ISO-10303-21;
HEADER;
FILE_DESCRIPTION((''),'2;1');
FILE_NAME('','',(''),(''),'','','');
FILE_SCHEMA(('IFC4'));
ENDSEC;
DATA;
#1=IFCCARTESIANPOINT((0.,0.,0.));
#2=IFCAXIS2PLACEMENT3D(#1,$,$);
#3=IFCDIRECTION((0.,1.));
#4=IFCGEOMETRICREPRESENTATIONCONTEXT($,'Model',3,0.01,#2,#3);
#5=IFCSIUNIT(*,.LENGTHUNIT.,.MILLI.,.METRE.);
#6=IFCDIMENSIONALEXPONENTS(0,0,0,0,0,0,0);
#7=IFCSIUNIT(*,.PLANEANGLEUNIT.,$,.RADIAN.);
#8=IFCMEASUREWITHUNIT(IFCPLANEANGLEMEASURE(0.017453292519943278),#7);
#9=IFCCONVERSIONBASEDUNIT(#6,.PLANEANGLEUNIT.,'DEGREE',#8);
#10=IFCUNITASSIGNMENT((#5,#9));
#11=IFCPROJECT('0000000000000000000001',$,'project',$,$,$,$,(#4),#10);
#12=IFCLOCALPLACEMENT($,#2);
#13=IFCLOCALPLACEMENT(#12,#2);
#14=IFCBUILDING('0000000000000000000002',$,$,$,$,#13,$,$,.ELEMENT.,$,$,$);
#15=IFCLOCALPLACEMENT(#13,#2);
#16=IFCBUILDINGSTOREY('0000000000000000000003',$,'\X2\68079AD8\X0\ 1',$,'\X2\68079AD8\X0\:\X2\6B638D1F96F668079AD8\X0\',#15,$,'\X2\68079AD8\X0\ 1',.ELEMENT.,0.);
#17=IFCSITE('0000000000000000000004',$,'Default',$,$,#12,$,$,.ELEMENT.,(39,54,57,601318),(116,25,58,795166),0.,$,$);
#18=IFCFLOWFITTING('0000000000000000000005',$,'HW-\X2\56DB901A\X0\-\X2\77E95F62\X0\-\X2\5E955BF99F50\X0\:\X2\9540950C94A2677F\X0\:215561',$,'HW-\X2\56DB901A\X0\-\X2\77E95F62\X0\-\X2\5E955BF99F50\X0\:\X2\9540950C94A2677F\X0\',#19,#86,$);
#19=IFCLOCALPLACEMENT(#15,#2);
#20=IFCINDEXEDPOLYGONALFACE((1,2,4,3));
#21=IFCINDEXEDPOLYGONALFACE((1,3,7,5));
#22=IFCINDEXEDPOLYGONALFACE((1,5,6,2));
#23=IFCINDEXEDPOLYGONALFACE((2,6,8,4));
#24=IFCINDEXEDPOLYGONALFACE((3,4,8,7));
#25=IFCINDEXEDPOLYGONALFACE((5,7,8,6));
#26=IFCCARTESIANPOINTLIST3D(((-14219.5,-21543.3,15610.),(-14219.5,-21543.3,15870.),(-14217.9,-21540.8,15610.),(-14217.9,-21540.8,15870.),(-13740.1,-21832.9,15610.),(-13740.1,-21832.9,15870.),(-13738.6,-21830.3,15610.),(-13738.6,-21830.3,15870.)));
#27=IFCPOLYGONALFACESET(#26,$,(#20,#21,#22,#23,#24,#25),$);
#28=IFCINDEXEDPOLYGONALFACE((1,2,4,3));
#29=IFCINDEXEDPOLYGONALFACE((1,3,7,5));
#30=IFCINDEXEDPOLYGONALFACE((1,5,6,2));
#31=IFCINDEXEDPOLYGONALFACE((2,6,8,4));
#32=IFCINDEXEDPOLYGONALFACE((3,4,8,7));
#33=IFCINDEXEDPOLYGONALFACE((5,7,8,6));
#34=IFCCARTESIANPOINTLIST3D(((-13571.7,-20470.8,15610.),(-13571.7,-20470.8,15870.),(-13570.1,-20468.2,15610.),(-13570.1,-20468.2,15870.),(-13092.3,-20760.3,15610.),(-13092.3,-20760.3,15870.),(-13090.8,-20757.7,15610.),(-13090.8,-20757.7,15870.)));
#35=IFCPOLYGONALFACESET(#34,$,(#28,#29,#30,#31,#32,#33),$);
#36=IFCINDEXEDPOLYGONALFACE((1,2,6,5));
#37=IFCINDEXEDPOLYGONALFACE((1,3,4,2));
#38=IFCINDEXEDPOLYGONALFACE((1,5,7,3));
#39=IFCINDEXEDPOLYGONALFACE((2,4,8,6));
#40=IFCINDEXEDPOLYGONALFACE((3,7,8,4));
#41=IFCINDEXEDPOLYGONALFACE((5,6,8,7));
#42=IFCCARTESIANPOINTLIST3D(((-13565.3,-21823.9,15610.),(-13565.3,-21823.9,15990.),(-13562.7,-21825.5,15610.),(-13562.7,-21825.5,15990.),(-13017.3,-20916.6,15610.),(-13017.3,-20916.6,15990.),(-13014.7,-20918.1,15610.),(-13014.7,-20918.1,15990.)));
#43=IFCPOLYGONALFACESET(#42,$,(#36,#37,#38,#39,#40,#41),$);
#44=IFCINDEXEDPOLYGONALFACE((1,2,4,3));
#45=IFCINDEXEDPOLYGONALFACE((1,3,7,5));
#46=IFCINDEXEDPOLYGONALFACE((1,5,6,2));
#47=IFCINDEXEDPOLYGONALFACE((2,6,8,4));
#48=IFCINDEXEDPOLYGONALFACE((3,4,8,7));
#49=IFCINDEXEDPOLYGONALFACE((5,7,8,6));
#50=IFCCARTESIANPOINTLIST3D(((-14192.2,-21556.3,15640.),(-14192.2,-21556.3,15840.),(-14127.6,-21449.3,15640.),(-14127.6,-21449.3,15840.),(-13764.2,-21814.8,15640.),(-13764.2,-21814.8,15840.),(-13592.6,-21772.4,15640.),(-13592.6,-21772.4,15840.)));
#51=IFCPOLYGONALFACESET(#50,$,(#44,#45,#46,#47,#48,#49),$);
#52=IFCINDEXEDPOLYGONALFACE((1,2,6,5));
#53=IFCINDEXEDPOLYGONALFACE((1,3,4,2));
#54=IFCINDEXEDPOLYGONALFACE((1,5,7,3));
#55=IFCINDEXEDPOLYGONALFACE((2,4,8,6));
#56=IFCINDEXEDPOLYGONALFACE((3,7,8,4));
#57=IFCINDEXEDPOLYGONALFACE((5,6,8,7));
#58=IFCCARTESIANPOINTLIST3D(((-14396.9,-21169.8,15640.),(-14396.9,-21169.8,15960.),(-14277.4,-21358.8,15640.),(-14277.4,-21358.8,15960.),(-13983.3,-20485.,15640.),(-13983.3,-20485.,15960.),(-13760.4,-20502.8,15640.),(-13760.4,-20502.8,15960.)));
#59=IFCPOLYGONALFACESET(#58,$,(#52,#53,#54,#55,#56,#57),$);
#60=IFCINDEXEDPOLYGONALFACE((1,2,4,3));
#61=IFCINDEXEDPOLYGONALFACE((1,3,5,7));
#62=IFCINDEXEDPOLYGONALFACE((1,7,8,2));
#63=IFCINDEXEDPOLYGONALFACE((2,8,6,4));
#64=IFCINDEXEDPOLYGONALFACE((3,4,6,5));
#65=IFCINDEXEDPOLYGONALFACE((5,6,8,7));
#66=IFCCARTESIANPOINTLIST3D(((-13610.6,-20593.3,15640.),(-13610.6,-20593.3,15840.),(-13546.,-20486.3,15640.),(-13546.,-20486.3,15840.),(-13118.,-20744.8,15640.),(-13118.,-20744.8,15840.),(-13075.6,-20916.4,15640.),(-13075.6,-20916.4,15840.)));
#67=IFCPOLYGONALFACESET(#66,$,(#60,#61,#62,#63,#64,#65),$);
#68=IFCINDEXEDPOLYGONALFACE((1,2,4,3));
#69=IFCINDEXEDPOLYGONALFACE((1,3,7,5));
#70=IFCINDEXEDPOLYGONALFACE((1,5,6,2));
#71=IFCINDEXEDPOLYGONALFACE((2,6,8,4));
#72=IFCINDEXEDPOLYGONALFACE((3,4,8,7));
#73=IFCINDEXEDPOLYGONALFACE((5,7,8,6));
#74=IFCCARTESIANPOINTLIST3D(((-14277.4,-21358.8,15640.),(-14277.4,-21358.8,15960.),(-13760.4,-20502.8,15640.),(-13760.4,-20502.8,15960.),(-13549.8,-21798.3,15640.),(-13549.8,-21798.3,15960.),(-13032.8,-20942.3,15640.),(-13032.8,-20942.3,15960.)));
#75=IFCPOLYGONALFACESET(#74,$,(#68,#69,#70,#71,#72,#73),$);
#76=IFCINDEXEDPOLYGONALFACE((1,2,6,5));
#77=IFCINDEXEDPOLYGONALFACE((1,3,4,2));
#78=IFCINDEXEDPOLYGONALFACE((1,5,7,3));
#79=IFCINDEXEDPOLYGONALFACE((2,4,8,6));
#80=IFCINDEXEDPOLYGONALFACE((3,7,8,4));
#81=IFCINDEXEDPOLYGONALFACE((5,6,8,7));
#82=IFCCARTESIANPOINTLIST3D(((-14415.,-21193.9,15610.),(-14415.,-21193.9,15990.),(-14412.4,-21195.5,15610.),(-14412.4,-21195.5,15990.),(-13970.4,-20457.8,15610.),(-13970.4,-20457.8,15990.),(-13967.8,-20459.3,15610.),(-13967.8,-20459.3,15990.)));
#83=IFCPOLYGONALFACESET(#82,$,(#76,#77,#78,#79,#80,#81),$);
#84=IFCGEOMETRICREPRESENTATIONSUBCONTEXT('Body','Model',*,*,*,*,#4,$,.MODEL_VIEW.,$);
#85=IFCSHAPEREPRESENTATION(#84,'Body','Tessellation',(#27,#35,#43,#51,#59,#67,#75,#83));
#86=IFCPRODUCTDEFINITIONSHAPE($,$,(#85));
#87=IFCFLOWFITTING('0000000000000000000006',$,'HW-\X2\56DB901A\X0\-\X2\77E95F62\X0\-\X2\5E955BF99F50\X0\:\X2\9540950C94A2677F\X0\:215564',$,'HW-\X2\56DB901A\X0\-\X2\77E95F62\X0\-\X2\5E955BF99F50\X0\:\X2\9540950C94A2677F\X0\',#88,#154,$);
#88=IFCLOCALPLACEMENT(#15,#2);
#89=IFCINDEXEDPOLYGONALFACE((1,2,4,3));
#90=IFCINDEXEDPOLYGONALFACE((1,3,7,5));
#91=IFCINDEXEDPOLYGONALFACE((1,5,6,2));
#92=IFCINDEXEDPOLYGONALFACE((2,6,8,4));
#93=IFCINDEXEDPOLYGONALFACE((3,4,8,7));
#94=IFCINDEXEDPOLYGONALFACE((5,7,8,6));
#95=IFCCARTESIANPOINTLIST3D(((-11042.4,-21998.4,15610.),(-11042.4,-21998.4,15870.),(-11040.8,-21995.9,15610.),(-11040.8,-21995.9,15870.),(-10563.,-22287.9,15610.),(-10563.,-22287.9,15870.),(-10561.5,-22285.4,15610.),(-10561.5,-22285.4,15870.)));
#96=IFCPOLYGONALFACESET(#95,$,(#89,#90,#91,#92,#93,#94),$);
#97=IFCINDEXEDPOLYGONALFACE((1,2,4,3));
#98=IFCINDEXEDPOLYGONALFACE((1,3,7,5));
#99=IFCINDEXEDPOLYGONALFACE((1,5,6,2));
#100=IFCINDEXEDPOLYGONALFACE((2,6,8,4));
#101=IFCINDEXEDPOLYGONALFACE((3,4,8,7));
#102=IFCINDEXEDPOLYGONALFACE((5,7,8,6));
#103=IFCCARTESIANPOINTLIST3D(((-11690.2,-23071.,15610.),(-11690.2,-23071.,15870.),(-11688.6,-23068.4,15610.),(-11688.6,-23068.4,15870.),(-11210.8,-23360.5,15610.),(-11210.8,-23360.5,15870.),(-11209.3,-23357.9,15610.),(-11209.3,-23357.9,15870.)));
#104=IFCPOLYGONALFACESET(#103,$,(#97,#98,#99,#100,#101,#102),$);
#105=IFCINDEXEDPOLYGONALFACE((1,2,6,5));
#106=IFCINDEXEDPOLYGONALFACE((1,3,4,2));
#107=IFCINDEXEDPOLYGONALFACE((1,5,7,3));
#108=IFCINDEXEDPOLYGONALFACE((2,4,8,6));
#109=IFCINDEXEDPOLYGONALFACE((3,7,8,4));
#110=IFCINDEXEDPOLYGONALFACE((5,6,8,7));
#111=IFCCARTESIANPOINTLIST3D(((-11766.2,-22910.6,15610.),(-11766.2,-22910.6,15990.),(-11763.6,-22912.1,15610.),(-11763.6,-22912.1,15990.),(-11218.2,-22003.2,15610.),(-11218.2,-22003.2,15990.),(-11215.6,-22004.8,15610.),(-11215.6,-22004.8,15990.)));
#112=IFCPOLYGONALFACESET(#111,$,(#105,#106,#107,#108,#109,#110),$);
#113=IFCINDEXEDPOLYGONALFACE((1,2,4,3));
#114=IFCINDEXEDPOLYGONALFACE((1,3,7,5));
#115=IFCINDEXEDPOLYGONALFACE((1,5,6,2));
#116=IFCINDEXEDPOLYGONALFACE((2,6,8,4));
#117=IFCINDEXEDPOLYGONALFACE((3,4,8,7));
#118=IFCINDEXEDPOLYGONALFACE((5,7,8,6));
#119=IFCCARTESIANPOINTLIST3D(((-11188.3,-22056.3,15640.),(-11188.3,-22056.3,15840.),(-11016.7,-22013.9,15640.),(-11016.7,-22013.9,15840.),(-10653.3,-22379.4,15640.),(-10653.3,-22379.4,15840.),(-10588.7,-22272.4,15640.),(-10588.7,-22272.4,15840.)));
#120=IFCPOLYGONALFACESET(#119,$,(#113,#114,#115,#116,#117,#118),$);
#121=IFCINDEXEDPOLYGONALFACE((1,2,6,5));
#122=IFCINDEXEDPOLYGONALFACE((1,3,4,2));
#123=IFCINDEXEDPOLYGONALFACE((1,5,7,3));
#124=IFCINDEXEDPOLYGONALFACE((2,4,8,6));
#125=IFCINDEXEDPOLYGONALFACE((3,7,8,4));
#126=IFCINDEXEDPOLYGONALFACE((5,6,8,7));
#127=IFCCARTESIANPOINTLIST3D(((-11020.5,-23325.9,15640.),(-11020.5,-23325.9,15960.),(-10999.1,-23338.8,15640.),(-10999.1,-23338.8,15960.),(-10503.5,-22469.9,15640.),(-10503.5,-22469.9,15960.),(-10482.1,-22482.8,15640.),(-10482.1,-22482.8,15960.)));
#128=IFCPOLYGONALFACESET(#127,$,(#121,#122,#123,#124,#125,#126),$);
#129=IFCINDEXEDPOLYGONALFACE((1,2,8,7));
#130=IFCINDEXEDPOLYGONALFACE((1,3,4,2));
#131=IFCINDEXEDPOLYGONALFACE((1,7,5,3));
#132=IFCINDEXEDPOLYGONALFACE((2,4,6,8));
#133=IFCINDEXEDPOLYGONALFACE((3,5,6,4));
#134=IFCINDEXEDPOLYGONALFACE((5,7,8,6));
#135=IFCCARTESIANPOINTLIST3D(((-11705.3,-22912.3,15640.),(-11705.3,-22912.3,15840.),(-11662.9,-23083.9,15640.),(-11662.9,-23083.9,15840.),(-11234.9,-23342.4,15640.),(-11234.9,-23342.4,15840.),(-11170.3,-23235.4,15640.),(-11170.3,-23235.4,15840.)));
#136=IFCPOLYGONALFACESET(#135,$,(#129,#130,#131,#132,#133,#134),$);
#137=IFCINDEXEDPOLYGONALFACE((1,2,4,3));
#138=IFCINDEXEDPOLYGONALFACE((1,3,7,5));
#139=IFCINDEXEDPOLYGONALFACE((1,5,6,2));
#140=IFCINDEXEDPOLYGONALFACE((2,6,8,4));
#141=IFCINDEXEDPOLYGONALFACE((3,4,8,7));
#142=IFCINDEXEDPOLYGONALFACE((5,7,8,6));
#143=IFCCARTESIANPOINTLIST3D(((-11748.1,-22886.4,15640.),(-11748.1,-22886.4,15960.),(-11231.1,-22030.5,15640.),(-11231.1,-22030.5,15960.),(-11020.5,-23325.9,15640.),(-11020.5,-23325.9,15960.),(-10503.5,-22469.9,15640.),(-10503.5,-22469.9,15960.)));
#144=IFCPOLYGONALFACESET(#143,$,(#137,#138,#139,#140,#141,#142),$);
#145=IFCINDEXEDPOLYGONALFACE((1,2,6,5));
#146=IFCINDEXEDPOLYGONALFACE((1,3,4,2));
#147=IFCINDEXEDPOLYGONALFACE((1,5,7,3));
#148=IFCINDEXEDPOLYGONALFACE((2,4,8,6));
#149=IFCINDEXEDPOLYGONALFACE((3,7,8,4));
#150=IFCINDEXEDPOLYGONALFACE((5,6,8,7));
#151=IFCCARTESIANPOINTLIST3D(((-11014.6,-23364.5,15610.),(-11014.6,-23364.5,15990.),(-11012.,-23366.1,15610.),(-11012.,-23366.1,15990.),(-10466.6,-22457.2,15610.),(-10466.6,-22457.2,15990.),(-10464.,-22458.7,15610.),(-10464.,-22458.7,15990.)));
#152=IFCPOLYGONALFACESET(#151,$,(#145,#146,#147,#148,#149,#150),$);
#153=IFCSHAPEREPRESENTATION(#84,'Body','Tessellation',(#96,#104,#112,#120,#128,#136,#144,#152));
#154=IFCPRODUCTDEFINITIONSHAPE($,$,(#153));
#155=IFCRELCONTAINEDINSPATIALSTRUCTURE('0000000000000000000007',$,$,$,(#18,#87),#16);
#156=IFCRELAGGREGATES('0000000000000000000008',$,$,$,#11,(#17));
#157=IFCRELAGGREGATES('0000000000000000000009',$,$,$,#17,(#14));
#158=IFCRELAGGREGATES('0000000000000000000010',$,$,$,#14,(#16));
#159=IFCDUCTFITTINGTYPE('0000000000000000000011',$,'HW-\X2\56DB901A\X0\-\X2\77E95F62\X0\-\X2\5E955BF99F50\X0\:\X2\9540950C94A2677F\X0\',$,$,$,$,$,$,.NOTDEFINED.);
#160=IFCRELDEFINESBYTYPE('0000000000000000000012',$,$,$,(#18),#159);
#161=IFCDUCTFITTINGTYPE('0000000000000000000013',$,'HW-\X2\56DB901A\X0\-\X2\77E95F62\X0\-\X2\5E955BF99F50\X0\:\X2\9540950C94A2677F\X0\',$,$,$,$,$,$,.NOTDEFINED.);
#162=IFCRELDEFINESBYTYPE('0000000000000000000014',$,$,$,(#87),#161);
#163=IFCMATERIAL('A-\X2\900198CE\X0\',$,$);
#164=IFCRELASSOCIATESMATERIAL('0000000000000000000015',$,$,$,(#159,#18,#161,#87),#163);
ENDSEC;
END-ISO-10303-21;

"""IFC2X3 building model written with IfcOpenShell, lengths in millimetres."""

from ifc_helpers import new_model, entity, si_unit, converted_unit, direction, frame, frame_2d, origin, origin_2d_with_axis, place, context, subcontext, project, spatial, polyline, rectangle, outline, extrude, source, transform, mapped, material, type_object, type_shapes, element, save


model = new_model("IFC2X3")

# Units and contexts
model_context = context("Model", 3, precision=0.01, world=origin(), true_north=direction((0.0, 1.0)))
body_context = subcontext(model_context, "Body", "Model", "MODEL_VIEW")
ifc_project = project(units=[si_unit("LENGTHUNIT", "METRE", prefix="MILLI"), converted_unit("PLANEANGLEUNIT", "DEGREE", entity("IfcPlaneAngleMeasure", 0.017453292519943278), si_unit("PLANEANGLEUNIT", "RADIAN"), dimensions=[0, 0, 0, 0, 0, 0, 0])], contexts=[model_context])

# Site, building, storey
site_placement = place(None, origin())
site = spatial("IfcSite", under=ifc_project, at=site_placement, Name="Default", CompositionType="ELEMENT", RefLatitude=(39, 54, 57, 601318), RefLongitude=(116, 25, 58, 795166), RefElevation=0.0)
building_placement = place(site_placement, origin())
building = spatial("IfcBuilding", under=site, at=building_placement, CompositionType="ELEMENT")
storey_placement = place(building_placement, origin())
storey = spatial("IfcBuildingStorey", under=building, at=storey_placement, Name="标高 1", ObjectType="标高:正负零标高", LongName="标高 1", CompositionType="ELEMENT", Elevation=0.0)

# Shared definitions
ifc_material = material(Name="A-送风")

# Flow fittings
duct_fitting_type_1 = type_object("IfcDuctFittingType", Name="HW-四通-矩形-底对齐:镀锌钢板", PredefinedType="NOTDEFINED", material=ifc_material)
shared_shape_1 = source(origin(), body_context, "Body", "SweptSolid", [
    extrude(rectangle(XDim=560.0, YDim=3.0, at=origin_2d_with_axis()), frame((0.0, 626.5, -190.0), z_axis=(0.0, 0.0, 1.0), x_axis=(-1.0, 0.0, 0.0)), (0.0, 0.0, 1.0), 260.0),
    extrude(rectangle(XDim=560.0, YDim=3.0, at=frame_2d((0.0, 0.0), x_axis=(1.0, 0.0))), frame((0.0, -626.5, -190.0), z_axis=(0.0, 0.0, 1.0), x_axis=(-1.0, 0.0, 0.0)), (0.0, 0.0, 1.0), 260.0),
    extrude(rectangle(XDim=1060.0, YDim=3.0, at=frame_2d((0.0, 0.0), x_axis=(1.0, 0.0))), frame((-426.5, 0.0, -190.0), z_axis=(0.0, 0.0, 1.0), x_axis=(0.0, 1.0, 0.0)), (0.0, 0.0, 1.0), 380.0),
    extrude(outline(polyline([(110.5, -198.9), (287.3, -198.9), (-154.7, 243.1), (-243.1, 154.7), (110.5, -198.9)])), frame((-31.2, 562.5, -160.0), z_axis=(0.0, 0.0, 1.0), x_axis=(-0.707107, -0.707107, 0.0)), (0.0, 0.0, 1.0), 200.0),
    extrude(outline(polyline([(89.4, -402.5), (313.0, -402.5), (-134.2, 491.9), (-268.3, 313.0), (89.4, -402.5)])), frame((525.0, 0.0, -160.0), z_axis=(0.0, 0.0, 1.0), x_axis=(-0.894427, 0.447214, 0.0)), (0.0, 0.0, 1.0), 320.0),
    extrude(outline(polyline([(-62.5, -281.2), (62.5, -281.2), (62.5, 343.8), (-62.5, 218.7), (-62.5, -281.2)])), frame((-31.3, -562.5, -160.0), z_axis=(0.0, 0.0, 1.0), x_axis=(0.0, 1.0, 0.0)), (0.0, 0.0, 1.0), 200.0),
    extrude(rectangle(XDim=850.0, YDim=1000.0, at=origin_2d_with_axis()), frame((0.0, 0.0, -160.0), z_axis=(0.0, 0.0, 1.0), x_axis=(-1.0, 0.0, 0.0)), (0.0, 0.0, 1.0), 320.0),
    extrude(rectangle(XDim=860.0, YDim=3.0, at=frame_2d((0.0, 0.0), x_axis=(1.0, 0.0))), frame((626.5, 0.0, -190.0), z_axis=(0.0, 0.0, 1.0), x_axis=(0.0, 1.0, 0.0)), (0.0, 0.0, 1.0), 380.0),
])
type_shapes(duct_fitting_type_1, [shared_shape_1])
flow_fitting_1_placement = place(storey_placement, frame((-13655.1, -21150.5, 15800.0), z_axis=(0.0, 0.0, 1.0), x_axis=(-0.855986, 0.516998, 0.0)))
element("IfcFlowFitting", 1, at=flow_fitting_1_placement, inside=storey, type_object=duct_fitting_type_1, material=ifc_material, Name="HW-四通-矩形-底对齐:镀锌钢板:215561", ObjectType="HW-四通-矩形-底对齐:镀锌钢板", context=body_context, shape_type="MappedRepresentation", body=[
    mapped(shared_shape_1, transform((0.0, 0.0, 0.0), scale=1.0)),
])
duct_fitting_type_2 = type_object("IfcDuctFittingType", Name="HW-四通-矩形-底对齐:镀锌钢板", PredefinedType="NOTDEFINED", material=ifc_material)
shared_shape_2 = source(origin(), body_context, "Body", "SweptSolid", [
    extrude(rectangle(XDim=560.0, YDim=3.0, at=origin_2d_with_axis()), frame((0.0, 626.5, -190.0), z_axis=(0.0, 0.0, 1.0), x_axis=(-1.0, 0.0, 0.0)), (0.0, 0.0, 1.0), 260.0),
    extrude(rectangle(XDim=560.0, YDim=3.0, at=frame_2d((0.0, 0.0), x_axis=(1.0, 0.0))), frame((0.0, -626.5, -190.0), z_axis=(0.0, 0.0, 1.0), x_axis=(-1.0, 0.0, 0.0)), (0.0, 0.0, 1.0), 260.0),
    extrude(rectangle(XDim=1060.0, YDim=3.0, at=frame_2d((0.0, 0.0), x_axis=(1.0, 0.0))), frame((-426.5, 0.0, -190.0), z_axis=(0.0, 0.0, 1.0), x_axis=(0.0, 1.0, 0.0)), (0.0, 0.0, 1.0), 380.0),
    extrude(outline(polyline([(110.5, -198.9), (287.3, -198.9), (-154.7, 243.1), (-243.1, 154.7), (110.5, -198.9)])), frame((-31.2, 562.5, -160.0), z_axis=(0.0, 0.0, 1.0), x_axis=(-0.707107, -0.707107, 0.0)), (0.0, 0.0, 1.0), 200.0),
    extrude(rectangle(XDim=25.0, YDim=1000.0, at=frame_2d((0.0, 0.0), x_axis=(1.0, 0.0))), frame((437.5, 0.0, -160.0), z_axis=(0.0, 0.0, 1.0), x_axis=(-1.0, 0.0, 0.0)), (0.0, 0.0, 1.0), 320.0),
    extrude(outline(polyline([(-62.5, -281.2), (62.5, -281.2), (62.5, 343.8), (-62.5, 218.7), (-62.5, -281.2)])), frame((-31.3, -562.5, -160.0), z_axis=(0.0, 0.0, 1.0), x_axis=(0.0, 1.0, 0.0)), (0.0, 0.0, 1.0), 200.0),
    extrude(rectangle(XDim=850.0, YDim=1000.0, at=origin_2d_with_axis()), frame((0.0, 0.0, -160.0), z_axis=(0.0, 0.0, 1.0), x_axis=(-1.0, 0.0, 0.0)), (0.0, 0.0, 1.0), 320.0),
    extrude(rectangle(XDim=1060.0, YDim=3.0, at=frame_2d((0.0, 0.0), x_axis=(1.0, 0.0))), frame((451.5, 0.0, -190.0), z_axis=(0.0, 0.0, 1.0), x_axis=(0.0, 1.0, 0.0)), (0.0, 0.0, 1.0), 380.0),
])
type_shapes(duct_fitting_type_2, [shared_shape_2])
flow_fitting_2_placement = place(storey_placement, frame((-11125.8, -22678.2, 15800.0), z_axis=(0.0, 0.0, 1.0), x_axis=(0.855986, -0.516998, 0.0)))
element("IfcFlowFitting", 2, at=flow_fitting_2_placement, inside=storey, type_object=duct_fitting_type_2, material=ifc_material, Name="HW-四通-矩形-底对齐:镀锌钢板:215564", ObjectType="HW-四通-矩形-底对齐:镀锌钢板", context=body_context, shape_type="MappedRepresentation", body=[
    mapped(shared_shape_2, transform((0.0, 0.0, 0.0), scale=1.0)),
])

save(model, "model.ifc")
